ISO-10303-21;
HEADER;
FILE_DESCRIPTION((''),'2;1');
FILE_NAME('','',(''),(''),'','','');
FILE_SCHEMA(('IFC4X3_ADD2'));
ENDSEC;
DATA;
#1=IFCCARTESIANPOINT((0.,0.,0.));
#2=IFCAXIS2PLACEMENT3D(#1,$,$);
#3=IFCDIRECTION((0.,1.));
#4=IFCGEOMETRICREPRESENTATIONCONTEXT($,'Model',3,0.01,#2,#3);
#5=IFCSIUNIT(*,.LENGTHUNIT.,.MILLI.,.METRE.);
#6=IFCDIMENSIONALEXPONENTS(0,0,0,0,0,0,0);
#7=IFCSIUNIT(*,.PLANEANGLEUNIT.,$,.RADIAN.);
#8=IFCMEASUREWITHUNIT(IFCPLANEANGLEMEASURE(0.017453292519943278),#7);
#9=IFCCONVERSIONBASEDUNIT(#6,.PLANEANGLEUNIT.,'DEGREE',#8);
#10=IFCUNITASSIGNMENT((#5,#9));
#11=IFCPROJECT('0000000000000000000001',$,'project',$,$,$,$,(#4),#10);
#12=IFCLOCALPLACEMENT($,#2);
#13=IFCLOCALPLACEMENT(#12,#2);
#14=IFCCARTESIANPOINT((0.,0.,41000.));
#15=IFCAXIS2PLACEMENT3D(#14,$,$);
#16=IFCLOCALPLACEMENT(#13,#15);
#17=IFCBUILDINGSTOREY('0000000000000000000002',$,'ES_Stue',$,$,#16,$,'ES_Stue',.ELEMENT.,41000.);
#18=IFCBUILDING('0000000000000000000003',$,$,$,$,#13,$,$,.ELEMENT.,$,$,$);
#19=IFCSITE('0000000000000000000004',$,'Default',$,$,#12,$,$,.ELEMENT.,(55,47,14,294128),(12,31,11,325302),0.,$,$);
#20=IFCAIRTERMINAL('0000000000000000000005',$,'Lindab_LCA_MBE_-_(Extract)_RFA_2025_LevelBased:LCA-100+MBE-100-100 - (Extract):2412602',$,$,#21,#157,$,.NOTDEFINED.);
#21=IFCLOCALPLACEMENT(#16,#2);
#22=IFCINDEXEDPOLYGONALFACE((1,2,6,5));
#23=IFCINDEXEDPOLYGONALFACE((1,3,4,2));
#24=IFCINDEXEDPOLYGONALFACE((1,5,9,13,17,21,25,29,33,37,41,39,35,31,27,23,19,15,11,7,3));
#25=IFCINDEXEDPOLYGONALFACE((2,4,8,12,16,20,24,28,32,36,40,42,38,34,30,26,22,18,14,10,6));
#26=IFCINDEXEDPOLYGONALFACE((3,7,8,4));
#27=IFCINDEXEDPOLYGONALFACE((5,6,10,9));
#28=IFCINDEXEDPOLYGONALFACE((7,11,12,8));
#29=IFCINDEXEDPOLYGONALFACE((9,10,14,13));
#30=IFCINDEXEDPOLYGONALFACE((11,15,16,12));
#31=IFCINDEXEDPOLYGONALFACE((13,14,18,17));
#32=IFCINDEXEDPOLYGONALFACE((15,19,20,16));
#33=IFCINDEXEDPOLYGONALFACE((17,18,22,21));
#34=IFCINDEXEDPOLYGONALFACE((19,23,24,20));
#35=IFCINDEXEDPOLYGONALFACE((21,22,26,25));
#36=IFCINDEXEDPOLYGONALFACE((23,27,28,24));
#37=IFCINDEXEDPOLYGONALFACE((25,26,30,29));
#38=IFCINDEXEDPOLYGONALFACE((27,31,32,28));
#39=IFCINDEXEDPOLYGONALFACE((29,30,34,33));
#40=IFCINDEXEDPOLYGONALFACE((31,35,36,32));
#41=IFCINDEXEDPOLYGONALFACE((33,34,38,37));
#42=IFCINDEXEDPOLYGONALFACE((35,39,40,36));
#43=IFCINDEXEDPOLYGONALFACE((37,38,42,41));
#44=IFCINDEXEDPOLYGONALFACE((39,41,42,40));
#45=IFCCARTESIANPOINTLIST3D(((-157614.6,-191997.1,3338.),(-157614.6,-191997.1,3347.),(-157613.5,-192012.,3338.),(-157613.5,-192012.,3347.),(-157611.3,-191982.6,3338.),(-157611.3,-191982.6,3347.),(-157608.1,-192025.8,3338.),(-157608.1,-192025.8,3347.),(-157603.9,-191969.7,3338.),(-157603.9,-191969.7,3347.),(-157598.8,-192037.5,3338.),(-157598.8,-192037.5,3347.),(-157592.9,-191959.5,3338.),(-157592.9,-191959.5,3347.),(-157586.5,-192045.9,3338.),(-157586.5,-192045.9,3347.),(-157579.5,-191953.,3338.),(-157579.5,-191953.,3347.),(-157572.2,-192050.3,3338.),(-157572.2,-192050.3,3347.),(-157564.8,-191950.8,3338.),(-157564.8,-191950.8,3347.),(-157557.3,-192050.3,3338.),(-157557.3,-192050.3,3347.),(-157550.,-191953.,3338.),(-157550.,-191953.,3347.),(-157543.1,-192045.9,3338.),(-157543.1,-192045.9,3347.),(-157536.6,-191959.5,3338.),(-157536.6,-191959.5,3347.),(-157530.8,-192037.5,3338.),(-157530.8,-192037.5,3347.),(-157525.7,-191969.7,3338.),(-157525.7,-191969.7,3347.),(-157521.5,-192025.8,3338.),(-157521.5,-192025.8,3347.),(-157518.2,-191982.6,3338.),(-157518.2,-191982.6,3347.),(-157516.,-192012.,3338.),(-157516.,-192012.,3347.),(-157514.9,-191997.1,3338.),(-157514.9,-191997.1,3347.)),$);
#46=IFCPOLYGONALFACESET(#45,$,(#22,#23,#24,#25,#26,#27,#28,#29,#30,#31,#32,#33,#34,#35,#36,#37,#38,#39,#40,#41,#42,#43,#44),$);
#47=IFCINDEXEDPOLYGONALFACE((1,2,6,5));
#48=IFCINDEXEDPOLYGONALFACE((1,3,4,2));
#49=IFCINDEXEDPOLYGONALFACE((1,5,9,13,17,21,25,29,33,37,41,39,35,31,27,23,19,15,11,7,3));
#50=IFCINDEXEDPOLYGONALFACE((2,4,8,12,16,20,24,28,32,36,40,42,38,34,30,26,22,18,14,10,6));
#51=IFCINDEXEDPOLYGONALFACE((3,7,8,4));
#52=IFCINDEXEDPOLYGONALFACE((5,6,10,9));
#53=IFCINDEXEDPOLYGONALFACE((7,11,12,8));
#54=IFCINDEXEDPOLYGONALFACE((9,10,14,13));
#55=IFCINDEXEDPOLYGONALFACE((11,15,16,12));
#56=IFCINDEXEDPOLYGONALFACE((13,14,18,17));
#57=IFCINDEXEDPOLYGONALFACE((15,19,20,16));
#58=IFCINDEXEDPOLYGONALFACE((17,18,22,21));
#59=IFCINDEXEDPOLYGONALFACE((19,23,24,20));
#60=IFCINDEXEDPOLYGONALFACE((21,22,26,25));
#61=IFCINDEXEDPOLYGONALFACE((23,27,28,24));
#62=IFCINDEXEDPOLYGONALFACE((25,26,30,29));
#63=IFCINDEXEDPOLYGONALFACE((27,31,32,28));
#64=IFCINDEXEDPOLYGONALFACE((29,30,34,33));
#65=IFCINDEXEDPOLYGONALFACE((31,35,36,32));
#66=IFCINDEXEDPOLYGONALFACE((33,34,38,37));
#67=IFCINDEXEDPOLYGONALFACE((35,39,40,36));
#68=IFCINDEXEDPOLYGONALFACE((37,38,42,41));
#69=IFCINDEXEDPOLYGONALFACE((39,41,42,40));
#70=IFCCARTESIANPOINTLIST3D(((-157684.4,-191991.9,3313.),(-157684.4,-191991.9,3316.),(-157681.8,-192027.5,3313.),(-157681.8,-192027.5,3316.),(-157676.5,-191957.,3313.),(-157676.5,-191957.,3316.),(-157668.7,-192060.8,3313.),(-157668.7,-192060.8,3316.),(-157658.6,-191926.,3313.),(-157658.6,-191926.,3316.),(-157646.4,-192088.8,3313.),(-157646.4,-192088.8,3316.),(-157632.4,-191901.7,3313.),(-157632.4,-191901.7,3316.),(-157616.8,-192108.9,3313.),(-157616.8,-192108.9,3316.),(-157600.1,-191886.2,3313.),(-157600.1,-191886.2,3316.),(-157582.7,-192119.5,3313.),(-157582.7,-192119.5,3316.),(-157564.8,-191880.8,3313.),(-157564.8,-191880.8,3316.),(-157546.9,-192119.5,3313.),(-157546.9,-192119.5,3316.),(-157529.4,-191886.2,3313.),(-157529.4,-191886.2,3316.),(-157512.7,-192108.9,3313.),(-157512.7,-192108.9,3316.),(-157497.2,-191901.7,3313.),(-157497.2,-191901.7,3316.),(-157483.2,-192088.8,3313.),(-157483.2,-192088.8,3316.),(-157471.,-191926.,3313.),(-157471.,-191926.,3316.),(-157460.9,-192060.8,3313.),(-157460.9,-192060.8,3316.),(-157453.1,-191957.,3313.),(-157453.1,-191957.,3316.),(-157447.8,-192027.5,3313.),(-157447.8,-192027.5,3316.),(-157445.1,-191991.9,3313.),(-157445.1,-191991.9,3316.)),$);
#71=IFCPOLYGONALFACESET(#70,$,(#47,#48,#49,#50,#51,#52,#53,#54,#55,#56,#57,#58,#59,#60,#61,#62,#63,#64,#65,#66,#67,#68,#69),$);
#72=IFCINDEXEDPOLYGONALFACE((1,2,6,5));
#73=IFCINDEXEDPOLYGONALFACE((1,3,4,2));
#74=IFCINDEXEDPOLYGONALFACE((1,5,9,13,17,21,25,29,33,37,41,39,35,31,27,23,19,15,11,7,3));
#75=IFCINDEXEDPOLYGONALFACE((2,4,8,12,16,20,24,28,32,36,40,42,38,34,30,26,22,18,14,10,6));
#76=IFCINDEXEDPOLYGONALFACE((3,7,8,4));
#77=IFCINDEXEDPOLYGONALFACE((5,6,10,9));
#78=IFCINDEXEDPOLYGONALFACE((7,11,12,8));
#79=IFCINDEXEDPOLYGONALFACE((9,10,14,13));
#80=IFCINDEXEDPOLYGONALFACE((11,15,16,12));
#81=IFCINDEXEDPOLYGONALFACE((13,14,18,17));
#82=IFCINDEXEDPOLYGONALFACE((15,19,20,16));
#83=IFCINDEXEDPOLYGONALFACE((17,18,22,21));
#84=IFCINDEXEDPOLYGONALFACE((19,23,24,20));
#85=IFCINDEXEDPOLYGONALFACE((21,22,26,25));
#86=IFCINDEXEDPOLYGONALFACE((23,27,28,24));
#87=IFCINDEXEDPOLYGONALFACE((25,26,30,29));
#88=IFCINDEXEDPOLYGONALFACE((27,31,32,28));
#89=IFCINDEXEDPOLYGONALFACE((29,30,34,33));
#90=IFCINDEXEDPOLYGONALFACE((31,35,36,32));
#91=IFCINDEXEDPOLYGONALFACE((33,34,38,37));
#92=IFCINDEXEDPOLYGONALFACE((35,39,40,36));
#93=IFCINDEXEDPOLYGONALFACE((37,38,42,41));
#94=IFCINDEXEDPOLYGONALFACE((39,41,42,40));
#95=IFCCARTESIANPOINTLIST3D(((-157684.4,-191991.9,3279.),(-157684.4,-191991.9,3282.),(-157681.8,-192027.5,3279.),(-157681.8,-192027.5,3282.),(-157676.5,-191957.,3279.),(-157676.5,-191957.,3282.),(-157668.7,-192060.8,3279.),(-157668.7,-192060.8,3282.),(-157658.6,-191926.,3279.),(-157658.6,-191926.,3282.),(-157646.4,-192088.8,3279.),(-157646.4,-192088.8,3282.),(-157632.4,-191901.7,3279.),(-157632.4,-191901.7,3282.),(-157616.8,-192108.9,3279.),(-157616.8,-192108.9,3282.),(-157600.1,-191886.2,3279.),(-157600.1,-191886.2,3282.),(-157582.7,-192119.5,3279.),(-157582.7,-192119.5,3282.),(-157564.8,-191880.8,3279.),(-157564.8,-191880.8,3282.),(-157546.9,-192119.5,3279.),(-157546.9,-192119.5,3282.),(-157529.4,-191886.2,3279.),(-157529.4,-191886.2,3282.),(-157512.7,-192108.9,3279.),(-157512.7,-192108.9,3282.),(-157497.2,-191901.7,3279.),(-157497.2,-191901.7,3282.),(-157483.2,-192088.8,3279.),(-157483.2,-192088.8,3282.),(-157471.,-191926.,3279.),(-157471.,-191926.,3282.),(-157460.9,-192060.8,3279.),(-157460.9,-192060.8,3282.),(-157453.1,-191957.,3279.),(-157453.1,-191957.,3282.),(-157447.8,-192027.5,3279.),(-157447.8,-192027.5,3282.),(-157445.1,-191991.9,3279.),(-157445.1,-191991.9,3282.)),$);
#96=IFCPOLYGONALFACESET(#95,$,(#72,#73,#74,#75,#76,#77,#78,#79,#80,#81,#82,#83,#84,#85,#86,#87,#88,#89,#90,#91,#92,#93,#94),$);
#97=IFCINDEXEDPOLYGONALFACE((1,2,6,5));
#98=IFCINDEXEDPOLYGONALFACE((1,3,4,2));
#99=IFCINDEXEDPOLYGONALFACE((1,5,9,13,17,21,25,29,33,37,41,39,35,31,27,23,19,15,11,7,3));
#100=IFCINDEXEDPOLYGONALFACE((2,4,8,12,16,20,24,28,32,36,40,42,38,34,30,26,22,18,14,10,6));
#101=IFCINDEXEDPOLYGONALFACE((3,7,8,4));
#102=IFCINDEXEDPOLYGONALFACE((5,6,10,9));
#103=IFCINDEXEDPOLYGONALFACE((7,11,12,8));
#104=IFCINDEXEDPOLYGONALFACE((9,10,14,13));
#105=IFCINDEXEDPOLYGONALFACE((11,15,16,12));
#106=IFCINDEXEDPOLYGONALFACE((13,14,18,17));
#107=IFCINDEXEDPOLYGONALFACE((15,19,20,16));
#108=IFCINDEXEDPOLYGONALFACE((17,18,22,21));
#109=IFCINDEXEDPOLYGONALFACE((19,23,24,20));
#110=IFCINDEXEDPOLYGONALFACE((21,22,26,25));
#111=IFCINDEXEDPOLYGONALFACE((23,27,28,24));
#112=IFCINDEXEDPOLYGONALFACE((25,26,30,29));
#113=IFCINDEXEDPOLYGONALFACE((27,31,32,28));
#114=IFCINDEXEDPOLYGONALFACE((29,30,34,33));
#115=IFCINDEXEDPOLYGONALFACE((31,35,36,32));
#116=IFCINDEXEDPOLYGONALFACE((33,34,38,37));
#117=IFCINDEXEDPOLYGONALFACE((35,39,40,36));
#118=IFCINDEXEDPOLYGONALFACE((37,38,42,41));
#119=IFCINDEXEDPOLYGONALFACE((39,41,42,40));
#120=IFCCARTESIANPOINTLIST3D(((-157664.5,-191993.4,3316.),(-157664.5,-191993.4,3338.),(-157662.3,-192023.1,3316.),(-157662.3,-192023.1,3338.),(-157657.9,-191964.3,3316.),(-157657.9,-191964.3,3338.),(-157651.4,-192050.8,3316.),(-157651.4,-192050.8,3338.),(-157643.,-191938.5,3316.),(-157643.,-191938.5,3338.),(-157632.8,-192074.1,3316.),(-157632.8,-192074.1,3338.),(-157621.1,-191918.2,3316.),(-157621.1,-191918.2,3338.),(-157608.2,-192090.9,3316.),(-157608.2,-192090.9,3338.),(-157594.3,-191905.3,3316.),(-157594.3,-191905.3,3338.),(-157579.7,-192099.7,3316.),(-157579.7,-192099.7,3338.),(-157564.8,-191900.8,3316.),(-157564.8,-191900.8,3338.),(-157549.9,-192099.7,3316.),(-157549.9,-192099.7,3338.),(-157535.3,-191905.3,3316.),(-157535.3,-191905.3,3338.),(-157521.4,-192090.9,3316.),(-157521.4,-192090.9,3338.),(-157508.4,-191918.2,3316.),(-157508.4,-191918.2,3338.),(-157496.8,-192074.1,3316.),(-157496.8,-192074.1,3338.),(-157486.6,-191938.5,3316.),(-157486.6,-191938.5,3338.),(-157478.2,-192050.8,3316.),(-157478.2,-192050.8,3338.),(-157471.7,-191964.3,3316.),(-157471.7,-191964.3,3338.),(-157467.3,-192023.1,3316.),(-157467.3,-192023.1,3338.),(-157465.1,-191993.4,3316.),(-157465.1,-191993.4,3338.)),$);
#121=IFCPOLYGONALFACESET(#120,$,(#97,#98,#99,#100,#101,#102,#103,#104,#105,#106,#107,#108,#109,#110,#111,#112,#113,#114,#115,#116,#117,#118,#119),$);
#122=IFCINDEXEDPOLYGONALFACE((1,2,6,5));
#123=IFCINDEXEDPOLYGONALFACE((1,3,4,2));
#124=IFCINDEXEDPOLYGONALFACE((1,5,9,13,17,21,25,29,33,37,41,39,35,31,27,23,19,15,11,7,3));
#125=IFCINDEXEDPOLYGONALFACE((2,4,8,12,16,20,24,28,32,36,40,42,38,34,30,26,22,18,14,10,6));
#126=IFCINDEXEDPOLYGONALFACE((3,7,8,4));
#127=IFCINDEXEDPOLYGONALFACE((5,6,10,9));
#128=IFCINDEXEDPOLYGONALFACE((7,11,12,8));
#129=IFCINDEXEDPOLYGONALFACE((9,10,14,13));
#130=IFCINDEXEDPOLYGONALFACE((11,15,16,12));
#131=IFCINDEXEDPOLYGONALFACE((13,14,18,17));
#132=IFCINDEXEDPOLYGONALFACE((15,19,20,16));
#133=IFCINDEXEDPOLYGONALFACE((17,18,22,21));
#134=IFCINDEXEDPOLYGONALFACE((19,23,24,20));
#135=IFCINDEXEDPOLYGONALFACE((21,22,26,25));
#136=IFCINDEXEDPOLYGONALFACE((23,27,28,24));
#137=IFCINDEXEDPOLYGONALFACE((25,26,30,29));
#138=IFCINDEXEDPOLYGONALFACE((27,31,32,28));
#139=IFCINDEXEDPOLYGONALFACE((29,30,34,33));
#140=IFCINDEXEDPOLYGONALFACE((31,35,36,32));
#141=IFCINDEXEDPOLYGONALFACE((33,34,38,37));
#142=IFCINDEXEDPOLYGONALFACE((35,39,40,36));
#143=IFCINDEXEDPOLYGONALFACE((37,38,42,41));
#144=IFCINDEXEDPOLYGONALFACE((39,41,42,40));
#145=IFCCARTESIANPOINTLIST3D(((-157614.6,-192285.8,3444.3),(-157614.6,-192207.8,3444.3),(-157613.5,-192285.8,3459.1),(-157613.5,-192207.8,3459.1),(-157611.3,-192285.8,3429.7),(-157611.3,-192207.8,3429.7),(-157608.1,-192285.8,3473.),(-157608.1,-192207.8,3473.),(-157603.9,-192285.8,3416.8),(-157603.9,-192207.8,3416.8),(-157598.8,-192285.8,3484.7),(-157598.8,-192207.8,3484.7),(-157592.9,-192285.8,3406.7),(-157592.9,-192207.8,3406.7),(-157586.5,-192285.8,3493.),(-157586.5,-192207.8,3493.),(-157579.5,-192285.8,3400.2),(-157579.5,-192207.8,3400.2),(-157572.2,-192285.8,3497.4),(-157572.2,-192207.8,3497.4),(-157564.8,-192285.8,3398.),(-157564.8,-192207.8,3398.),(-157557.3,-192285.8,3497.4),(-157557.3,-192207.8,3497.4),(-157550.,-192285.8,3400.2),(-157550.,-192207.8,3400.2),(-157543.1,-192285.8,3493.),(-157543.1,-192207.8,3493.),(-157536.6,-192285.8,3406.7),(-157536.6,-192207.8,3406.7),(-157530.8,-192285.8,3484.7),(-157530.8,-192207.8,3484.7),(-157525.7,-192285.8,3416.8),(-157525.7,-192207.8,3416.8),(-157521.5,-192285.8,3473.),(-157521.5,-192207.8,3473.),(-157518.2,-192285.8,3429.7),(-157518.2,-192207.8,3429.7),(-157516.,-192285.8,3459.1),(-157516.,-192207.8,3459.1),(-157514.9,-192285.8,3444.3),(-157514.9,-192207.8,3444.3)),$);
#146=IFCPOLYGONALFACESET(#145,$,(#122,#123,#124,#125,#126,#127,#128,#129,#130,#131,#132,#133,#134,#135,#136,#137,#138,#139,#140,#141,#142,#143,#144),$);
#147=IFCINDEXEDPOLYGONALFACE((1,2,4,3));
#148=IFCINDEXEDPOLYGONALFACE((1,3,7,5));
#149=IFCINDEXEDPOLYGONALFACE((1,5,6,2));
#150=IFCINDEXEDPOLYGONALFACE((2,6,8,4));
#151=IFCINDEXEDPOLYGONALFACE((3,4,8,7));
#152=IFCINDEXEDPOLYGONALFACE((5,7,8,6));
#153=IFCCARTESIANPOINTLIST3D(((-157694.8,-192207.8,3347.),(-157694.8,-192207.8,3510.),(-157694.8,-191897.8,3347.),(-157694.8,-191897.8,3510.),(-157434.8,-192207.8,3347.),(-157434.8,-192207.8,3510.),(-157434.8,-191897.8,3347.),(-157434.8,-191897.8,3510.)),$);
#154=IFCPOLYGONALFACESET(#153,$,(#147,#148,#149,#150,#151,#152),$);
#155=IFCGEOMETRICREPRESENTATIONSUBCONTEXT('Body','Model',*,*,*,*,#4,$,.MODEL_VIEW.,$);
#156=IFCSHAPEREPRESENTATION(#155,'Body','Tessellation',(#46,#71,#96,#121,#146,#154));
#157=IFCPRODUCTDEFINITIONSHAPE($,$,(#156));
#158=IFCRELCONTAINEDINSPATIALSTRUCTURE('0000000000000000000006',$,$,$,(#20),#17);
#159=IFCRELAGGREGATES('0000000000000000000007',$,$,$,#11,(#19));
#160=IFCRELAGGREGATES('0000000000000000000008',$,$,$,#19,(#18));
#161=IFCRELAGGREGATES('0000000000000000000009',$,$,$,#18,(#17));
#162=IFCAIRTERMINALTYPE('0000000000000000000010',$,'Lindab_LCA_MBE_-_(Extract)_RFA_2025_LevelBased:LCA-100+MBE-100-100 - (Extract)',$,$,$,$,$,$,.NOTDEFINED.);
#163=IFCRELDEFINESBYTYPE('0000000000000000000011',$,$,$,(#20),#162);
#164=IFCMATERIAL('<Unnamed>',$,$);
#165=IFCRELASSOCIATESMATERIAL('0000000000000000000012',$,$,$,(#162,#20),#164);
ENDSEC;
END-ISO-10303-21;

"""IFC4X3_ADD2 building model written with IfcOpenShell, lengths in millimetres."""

from ifc_helpers import new_model, entity, si_unit, converted_unit, direction, frame, frame_2d, origin, origin_2d_with_axis, place, context, subcontext, project, spatial, rectangle, circle, extrude, source, transform, mapped, material, type_object, type_shapes, element, save


model = new_model("IFC4X3_ADD2")

# Units and contexts
model_context = context("Model", 3, precision=0.01, world=origin(), true_north=direction((0.0, 1.0)))
body_context = subcontext(model_context, "Body", "Model", "MODEL_VIEW")
ifc_project = project(units=[si_unit("LENGTHUNIT", "METRE", prefix="MILLI"), converted_unit("PLANEANGLEUNIT", "DEGREE", entity("IfcPlaneAngleMeasure", 0.017453292519943278), si_unit("PLANEANGLEUNIT", "RADIAN"), dimensions=[0, 0, 0, 0, 0, 0, 0])], contexts=[model_context])

# Site, building, storey
site_placement = place(None, origin())
site = spatial("IfcSite", under=ifc_project, at=site_placement, Name="Default", CompositionType="ELEMENT", RefLatitude=(55, 47, 14, 294128), RefLongitude=(12, 31, 11, 325302), RefElevation=0.0)
building_placement = place(site_placement, origin())
building = spatial("IfcBuilding", under=site, at=building_placement, CompositionType="ELEMENT")
storey_placement = place(building_placement, frame((0.0, 0.0, 41000.0)))
storey = spatial("IfcBuildingStorey", under=building, at=storey_placement, Name="ES_Stue", LongName="ES_Stue", CompositionType="ELEMENT", Elevation=41000.0)

# Air terminal
ifc_material_1 = material(Name="<Unnamed>")
air_terminal_type_1 = type_object("IfcAirTerminalType", Name="Lindab_LCA_MBE_-_(Extract)_RFA_2025_LevelBased:LCA-100+MBE-100-100 - (Extract)", PredefinedType="NOTDEFINED", material=ifc_material_1)
shared_shape_1 = source(origin(), body_context, "Body", "SweptSolid", [
    extrude(circle(Radius=50.0, at=frame_2d((0.0, 0.0), x_axis=(1.0, 0.0))), frame((0.0, 0.0, 22.0)), (0.0, 0.0, 1.0), 9.0),
    extrude(circle(Radius=120.0, at=frame_2d((0.0, 0.0), x_axis=(1.0, 0.0))), frame((0.0, 0.0, -3.0)), (0.0, 0.0, 1.0), 3.0),
    extrude(circle(Radius=120.0, at=frame_2d((0.0, 0.0), x_axis=(1.0, 0.0))), frame((0.0, 0.0, -37.0)), (0.0, 0.0, 1.0), 3.0),
    extrude(circle(Radius=100.0, at=frame_2d((0.0, 0.0), x_axis=(1.0, 0.0))), origin(), (0.0, 0.0, 1.0), 22.0),
    extrude(circle(Radius=50.0, at=frame_2d((0.0, 0.0), x_axis=(1.0, 0.0))), frame((-285.0, 0.0, 132.0), z_axis=(1.0, 0.0, 0.0), x_axis=(0.0, 0.0, -1.0)), (0.0, 0.0, 1.0), 78.0),
    extrude(rectangle(XDim=260.0, YDim=310.0, at=origin_2d_with_axis()), frame((-52.0, 0.0, 31.0), z_axis=(0.0, 0.0, 1.0), x_axis=(0.0, -1.0, 0.0)), (0.0, 0.0, 1.0), 163.0),
])
type_shapes(air_terminal_type_1, [shared_shape_1])
air_terminal_1_placement = place(storey_placement, frame((-157564.8, -192000.8, 3316.0), z_axis=(0.0, 0.0, 1.0), x_axis=(0.0, 1.0, 0.0)))
element("IfcAirTerminal", 1, at=air_terminal_1_placement, inside=storey, type_object=air_terminal_type_1, material=ifc_material_1, Name="Lindab_LCA_MBE_-_(Extract)_RFA_2025_LevelBased:LCA-100+MBE-100-100 - (Extract):2412602", PredefinedType="NOTDEFINED", context=body_context, shape_type="MappedRepresentation", body=[
    mapped(shared_shape_1, transform((0.0, 0.0, 0.0), scale=1.0)),
])

save(model, "model.ifc")
